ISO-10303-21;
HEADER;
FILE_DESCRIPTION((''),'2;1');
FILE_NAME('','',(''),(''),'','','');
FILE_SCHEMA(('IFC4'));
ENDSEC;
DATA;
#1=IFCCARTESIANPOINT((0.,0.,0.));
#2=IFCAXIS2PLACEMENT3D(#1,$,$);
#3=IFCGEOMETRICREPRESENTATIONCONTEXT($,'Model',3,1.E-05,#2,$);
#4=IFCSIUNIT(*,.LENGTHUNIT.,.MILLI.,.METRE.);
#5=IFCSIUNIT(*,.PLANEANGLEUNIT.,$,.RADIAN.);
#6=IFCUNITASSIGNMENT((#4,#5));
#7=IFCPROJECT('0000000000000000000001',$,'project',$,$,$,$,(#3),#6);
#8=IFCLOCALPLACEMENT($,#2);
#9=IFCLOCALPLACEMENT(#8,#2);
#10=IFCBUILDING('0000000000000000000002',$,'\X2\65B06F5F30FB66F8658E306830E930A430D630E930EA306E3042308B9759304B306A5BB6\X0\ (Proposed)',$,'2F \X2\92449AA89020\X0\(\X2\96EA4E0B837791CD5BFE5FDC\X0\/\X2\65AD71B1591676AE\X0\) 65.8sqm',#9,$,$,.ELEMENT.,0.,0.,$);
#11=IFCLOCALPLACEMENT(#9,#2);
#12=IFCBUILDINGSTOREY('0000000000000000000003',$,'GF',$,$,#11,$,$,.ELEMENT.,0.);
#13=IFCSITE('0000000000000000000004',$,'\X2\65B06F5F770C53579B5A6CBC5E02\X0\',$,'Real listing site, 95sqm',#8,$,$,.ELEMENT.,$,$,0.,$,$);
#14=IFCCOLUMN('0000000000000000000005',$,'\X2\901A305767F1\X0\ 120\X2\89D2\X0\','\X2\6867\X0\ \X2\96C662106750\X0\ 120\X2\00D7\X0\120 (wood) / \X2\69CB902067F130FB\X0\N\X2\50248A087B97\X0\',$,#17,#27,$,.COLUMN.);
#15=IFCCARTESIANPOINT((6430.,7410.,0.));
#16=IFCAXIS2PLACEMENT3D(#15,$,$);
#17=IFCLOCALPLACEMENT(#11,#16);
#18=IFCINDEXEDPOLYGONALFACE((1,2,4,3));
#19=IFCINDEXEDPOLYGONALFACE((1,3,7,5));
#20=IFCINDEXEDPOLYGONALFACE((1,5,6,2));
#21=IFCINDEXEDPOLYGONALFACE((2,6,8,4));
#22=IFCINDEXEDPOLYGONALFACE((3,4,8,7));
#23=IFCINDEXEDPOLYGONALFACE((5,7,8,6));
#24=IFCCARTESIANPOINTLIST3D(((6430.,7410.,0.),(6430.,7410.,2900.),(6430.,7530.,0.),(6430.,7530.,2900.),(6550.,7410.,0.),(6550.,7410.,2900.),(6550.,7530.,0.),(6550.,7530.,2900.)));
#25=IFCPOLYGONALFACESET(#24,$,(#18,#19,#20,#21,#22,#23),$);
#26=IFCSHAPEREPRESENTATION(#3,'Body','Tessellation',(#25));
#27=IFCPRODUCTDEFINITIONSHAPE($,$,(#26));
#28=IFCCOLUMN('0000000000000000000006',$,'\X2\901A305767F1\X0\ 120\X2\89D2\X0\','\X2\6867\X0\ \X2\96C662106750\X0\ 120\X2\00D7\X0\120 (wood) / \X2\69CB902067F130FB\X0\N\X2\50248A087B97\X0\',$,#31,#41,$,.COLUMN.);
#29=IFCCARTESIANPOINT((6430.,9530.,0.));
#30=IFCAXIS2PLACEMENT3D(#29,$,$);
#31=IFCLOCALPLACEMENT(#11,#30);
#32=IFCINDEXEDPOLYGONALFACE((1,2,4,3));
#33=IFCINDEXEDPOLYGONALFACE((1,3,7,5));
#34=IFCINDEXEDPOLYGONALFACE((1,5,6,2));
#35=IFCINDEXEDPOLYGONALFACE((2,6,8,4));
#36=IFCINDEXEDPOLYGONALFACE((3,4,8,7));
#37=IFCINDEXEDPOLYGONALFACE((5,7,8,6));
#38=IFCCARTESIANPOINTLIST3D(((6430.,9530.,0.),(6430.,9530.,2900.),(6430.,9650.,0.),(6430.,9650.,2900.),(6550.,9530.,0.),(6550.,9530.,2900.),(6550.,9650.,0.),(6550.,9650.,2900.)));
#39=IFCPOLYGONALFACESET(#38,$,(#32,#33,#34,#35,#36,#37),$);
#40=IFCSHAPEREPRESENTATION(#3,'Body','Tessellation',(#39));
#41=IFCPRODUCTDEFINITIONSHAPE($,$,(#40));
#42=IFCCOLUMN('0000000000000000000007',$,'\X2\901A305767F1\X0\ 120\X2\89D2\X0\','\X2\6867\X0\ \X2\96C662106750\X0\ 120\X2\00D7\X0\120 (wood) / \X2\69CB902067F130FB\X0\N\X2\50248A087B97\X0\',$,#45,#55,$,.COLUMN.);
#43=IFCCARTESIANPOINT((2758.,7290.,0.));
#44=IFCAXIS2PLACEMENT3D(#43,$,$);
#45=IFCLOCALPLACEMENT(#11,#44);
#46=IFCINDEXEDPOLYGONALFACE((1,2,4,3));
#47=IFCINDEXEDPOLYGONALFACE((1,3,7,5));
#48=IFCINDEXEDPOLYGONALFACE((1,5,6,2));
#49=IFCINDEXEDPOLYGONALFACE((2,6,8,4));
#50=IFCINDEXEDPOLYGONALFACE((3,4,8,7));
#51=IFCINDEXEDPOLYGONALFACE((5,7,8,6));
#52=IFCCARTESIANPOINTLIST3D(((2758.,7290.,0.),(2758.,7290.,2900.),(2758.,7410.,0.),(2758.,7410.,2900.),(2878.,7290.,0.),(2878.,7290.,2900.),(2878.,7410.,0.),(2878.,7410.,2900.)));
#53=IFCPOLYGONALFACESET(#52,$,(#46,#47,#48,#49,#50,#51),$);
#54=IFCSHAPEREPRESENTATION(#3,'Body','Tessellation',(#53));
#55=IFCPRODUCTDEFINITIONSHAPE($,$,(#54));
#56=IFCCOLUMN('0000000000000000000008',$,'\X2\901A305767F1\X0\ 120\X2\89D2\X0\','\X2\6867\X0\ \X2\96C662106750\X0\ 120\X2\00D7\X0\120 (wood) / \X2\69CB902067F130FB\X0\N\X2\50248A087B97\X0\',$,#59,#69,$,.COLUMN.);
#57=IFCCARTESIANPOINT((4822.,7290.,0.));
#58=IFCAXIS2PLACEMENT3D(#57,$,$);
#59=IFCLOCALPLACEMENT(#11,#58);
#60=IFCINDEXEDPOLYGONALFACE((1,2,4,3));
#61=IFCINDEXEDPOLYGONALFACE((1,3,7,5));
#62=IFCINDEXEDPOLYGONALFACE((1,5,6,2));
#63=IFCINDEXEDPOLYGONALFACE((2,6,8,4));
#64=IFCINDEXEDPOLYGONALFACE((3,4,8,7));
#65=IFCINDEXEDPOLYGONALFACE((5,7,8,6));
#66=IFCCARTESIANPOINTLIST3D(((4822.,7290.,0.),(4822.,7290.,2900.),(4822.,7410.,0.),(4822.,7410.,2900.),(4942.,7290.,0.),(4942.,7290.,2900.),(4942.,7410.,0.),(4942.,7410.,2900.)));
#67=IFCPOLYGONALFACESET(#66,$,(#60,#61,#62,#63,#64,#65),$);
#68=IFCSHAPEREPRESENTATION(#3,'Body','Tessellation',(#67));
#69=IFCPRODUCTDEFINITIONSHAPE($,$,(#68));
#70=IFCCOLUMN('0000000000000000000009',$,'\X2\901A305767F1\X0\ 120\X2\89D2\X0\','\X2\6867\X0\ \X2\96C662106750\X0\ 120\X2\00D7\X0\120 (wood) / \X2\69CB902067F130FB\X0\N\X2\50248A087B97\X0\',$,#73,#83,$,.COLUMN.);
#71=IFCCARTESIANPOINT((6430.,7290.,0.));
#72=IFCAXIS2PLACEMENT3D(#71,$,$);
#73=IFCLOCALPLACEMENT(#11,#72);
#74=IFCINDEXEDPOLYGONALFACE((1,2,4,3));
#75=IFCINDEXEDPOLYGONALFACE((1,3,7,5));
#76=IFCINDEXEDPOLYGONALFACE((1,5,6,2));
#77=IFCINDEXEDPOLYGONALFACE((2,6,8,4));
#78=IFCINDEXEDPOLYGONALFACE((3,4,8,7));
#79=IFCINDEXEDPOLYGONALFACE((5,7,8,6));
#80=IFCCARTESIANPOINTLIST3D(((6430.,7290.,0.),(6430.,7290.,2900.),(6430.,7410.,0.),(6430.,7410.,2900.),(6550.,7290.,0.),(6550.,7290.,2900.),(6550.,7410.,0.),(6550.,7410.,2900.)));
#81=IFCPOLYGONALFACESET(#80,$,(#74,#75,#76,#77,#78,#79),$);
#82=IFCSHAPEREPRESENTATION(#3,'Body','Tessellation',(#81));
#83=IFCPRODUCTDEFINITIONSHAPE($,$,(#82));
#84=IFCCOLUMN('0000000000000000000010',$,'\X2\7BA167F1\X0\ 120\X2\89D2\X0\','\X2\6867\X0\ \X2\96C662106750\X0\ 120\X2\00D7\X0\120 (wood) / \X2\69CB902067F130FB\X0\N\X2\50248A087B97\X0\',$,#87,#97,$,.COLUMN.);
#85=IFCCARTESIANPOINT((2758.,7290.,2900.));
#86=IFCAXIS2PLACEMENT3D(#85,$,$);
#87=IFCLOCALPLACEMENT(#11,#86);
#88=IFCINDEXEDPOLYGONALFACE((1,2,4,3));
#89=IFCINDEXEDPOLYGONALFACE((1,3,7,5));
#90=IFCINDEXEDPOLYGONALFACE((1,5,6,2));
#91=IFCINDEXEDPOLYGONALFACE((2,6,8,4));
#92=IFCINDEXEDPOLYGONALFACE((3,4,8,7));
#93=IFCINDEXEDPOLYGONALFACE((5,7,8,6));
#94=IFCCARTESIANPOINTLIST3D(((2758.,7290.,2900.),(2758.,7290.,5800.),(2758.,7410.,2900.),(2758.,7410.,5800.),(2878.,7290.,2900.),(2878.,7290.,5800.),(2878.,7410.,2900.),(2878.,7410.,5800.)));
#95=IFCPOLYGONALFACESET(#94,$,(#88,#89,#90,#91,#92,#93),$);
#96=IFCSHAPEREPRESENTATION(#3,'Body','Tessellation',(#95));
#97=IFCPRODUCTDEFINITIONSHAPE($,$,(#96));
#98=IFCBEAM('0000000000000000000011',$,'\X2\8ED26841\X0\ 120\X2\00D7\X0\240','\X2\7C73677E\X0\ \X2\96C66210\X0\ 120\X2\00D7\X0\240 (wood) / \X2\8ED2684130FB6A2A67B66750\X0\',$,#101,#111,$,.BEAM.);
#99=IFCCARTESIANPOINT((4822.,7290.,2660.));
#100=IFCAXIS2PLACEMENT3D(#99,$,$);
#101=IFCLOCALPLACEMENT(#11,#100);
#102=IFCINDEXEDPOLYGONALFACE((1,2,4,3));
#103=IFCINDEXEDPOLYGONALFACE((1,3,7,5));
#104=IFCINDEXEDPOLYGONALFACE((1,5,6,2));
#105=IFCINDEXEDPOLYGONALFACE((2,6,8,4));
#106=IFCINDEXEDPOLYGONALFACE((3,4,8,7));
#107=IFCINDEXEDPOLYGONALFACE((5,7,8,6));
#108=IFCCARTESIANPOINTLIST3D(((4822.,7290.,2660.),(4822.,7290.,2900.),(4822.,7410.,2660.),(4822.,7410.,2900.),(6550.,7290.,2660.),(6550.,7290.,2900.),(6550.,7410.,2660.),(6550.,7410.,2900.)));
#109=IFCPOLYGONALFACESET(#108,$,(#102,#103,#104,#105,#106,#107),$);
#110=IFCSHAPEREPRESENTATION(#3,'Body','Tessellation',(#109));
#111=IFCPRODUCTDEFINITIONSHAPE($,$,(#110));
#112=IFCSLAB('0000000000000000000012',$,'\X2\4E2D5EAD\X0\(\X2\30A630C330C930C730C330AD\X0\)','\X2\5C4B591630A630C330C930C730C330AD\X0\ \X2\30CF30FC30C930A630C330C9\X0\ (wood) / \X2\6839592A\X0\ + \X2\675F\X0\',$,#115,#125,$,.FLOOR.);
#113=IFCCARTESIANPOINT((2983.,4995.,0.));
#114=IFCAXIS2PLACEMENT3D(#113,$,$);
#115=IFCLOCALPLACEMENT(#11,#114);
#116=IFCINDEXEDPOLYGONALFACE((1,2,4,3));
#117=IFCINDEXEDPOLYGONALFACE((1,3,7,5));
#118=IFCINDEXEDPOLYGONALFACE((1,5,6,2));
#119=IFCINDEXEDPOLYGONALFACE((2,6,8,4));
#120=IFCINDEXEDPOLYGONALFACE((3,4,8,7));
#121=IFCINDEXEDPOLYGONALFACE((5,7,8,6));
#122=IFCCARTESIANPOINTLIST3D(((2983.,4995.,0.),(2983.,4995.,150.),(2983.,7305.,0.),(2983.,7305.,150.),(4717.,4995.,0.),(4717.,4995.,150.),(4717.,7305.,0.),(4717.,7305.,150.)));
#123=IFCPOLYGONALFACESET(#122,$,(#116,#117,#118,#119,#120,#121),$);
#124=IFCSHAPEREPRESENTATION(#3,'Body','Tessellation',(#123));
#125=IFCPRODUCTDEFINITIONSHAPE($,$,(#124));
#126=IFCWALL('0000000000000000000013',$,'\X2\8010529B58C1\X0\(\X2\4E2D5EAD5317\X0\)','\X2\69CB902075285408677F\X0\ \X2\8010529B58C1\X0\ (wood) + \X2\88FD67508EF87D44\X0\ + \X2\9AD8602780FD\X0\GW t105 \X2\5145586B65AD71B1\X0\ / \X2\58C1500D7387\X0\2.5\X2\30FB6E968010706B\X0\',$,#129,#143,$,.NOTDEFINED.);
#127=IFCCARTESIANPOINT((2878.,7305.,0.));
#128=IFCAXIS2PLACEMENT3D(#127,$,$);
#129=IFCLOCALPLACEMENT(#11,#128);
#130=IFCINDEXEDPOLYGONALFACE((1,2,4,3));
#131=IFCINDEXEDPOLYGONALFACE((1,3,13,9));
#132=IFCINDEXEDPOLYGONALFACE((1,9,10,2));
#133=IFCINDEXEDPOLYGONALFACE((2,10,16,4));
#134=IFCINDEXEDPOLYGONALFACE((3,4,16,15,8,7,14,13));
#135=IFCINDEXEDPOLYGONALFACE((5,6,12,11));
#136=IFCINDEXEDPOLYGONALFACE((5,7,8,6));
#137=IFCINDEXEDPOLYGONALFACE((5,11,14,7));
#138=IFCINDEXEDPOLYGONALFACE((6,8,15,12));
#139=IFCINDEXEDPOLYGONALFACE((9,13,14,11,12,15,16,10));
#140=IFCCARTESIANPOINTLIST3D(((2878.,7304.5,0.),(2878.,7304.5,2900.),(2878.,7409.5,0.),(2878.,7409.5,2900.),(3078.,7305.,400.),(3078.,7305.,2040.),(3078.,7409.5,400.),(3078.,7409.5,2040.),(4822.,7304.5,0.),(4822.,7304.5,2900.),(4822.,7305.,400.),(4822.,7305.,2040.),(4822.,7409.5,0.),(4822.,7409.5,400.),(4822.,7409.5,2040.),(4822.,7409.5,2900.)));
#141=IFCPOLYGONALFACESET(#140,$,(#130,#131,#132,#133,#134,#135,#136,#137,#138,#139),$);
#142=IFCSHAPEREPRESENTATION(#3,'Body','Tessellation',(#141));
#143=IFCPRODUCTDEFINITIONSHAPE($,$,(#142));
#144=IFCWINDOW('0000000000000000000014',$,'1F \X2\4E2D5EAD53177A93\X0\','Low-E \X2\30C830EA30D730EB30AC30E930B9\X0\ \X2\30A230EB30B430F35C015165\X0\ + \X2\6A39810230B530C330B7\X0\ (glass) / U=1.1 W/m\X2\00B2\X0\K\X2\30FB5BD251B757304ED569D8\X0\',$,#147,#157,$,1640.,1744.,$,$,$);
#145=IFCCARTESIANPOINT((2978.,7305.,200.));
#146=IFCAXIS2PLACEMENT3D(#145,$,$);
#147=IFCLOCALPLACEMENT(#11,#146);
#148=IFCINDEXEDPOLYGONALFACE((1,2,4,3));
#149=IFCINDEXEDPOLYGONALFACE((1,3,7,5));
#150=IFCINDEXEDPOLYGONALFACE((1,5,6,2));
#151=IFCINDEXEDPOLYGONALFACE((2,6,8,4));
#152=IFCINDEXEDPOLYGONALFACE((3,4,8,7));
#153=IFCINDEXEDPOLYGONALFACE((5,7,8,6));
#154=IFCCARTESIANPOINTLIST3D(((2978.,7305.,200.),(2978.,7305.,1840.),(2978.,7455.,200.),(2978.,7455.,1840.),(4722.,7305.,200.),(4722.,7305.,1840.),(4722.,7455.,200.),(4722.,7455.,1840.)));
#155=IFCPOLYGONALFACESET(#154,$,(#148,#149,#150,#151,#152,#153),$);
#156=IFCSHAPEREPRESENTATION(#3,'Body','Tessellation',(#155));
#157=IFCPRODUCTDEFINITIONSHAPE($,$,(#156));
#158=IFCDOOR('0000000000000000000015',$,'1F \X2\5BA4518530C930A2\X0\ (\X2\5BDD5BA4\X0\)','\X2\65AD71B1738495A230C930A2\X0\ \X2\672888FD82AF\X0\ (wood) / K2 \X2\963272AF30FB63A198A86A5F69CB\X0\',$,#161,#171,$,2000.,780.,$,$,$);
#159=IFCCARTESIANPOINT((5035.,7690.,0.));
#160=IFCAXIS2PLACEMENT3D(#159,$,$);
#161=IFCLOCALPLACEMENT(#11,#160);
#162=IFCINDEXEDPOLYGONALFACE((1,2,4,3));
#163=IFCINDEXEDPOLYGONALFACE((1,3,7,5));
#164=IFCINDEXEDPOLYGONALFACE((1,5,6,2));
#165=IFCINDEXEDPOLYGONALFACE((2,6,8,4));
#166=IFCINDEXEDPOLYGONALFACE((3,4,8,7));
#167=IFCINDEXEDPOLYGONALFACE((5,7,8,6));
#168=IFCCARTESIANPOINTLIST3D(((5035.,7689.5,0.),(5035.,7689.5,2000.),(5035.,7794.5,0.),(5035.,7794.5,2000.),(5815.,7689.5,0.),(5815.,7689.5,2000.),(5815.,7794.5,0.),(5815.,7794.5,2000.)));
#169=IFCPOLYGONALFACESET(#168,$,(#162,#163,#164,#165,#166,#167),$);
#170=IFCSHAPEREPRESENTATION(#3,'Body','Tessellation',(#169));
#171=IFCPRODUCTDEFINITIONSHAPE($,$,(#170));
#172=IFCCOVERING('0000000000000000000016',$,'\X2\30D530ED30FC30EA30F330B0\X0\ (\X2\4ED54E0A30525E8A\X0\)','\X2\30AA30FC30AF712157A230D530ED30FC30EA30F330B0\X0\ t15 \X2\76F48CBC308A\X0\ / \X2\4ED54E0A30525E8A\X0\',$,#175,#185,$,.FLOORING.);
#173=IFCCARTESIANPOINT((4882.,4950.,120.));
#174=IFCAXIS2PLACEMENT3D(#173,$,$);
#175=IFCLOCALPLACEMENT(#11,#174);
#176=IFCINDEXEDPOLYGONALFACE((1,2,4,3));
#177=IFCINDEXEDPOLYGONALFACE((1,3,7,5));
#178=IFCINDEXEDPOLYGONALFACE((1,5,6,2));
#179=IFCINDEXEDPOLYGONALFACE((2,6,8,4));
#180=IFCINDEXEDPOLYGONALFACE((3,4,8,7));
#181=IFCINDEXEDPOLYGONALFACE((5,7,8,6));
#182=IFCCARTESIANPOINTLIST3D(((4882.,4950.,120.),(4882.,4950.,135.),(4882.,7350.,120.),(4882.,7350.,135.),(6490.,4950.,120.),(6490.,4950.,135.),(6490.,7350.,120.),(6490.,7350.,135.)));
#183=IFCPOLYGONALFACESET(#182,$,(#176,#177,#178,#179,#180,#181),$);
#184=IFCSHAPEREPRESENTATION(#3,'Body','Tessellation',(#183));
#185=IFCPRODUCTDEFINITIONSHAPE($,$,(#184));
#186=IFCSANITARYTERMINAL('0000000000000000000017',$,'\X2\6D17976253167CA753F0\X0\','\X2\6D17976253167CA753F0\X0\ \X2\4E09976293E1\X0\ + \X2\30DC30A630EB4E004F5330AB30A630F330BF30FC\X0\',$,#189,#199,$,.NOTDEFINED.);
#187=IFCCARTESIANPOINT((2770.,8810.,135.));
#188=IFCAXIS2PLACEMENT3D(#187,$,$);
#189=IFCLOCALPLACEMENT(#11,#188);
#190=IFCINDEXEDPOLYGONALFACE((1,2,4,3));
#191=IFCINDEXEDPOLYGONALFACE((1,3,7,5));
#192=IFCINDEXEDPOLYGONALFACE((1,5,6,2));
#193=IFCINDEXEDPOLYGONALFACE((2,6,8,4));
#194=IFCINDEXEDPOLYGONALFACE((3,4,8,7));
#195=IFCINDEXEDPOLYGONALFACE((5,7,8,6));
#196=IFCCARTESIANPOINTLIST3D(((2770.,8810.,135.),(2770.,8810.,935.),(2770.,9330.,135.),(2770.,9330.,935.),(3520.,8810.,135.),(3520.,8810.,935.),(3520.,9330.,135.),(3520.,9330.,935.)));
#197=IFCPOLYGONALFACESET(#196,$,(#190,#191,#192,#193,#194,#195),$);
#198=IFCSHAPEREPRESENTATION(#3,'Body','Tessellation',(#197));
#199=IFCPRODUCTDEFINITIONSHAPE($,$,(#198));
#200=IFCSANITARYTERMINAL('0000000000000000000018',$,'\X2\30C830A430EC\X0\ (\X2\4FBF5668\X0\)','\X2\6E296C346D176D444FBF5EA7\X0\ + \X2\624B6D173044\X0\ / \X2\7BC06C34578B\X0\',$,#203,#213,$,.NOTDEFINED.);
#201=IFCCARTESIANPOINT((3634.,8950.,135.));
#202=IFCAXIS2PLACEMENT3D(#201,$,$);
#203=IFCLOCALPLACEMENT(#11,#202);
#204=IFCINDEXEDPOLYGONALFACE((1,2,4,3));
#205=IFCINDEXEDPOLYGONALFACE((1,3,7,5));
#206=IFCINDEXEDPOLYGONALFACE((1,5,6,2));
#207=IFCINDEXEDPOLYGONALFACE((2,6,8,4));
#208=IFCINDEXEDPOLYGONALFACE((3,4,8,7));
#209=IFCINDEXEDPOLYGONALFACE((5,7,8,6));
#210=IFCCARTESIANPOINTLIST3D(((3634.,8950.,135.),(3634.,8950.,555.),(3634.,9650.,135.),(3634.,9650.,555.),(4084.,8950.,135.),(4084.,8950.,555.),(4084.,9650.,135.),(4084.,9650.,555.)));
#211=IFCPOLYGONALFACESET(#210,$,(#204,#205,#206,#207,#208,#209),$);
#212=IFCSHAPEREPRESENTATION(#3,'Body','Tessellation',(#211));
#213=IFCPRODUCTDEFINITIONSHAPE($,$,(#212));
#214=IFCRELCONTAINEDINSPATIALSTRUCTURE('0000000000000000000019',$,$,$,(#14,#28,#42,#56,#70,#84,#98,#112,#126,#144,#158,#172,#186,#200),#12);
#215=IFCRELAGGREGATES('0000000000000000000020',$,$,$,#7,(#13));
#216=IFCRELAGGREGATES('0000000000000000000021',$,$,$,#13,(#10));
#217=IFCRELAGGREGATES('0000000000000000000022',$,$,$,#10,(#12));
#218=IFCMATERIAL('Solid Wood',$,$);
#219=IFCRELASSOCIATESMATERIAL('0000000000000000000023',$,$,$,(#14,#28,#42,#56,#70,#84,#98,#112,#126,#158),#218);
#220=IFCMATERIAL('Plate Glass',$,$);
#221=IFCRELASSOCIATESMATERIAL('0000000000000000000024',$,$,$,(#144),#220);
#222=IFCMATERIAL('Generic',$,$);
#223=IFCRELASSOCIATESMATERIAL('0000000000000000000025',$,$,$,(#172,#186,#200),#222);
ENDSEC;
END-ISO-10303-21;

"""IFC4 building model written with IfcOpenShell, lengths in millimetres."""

from ifc_helpers import new_model, si_unit, frame, frame_2d, origin, place, context, project, spatial, rectangle, extrude, material, element, fill, save


model = new_model("IFC4")

# Units and contexts
model_context = context("Model", 3, precision=1e-05, world=origin())
ifc_project = project(units=[si_unit("LENGTHUNIT", "METRE", prefix="MILLI"), si_unit("PLANEANGLEUNIT", "RADIAN")], contexts=[model_context])

# Site, building, storey
site_placement = place(None, origin())
site = spatial("IfcSite", under=ifc_project, at=site_placement, Name="新潟県南魚沼市", ObjectType="Real listing site, 95sqm", CompositionType="ELEMENT", RefElevation=0.0)
building_placement = place(site_placement, origin())
building = spatial("IfcBuilding", under=site, at=building_placement, Name="新潟・書斎とライブラリのある静かな家 (Proposed)", ObjectType="2F 鉄骨造(雪下荷重対応/断熱外皮) 65.8sqm", CompositionType="ELEMENT", ElevationOfRefHeight=0.0, ElevationOfTerrain=0.0)
storey_placement = place(building_placement, origin())
storey = spatial("IfcBuildingStorey", under=building, at=storey_placement, Name="GF", CompositionType="ELEMENT", Elevation=0.0)

# Columns
ifc_material_1 = material(Name="Solid Wood")
column_1_placement = place(storey_placement, frame((6430.0, 7410.0, 0.0)))
element("IfcColumn", 1, at=column_1_placement, inside=storey, material=ifc_material_1, Name="通し柱 120角", Description="桧 集成材 120×120 (wood) / 構造柱・N値計算", PredefinedType="COLUMN", context=model_context, shape_type="SweptSolid", body=[
    extrude(rectangle(XDim=120.0, YDim=120.0, at=frame_2d((60.0, 60.0))), frame((6430.0, 7410.0, 0.0)), (0.0, 0.0, 1.0), 2900.0),
])
column_2_placement = place(storey_placement, frame((6430.0, 9530.0, 0.0)))
element("IfcColumn", 2, at=column_2_placement, inside=storey, material=ifc_material_1, Name="通し柱 120角", Description="桧 集成材 120×120 (wood) / 構造柱・N値計算", PredefinedType="COLUMN", context=model_context, shape_type="SweptSolid", body=[
    extrude(rectangle(XDim=120.0, YDim=120.0, at=frame_2d((60.0, 60.0))), frame((6430.0, 9530.0, 0.0)), (0.0, 0.0, 1.0), 2900.0),
])
column_3_placement = place(storey_placement, frame((2758.0, 7290.0, 0.0)))
element("IfcColumn", 3, at=column_3_placement, inside=storey, material=ifc_material_1, Name="通し柱 120角", Description="桧 集成材 120×120 (wood) / 構造柱・N値計算", PredefinedType="COLUMN", context=model_context, shape_type="SweptSolid", body=[
    extrude(rectangle(XDim=120.0, YDim=120.0, at=frame_2d((60.0, 60.0))), frame((2758.0, 7290.0, 0.0)), (0.0, 0.0, 1.0), 2900.0),
])
column_4_placement = place(storey_placement, frame((4822.0, 7290.0, 0.0)))
element("IfcColumn", 4, at=column_4_placement, inside=storey, material=ifc_material_1, Name="通し柱 120角", Description="桧 集成材 120×120 (wood) / 構造柱・N値計算", PredefinedType="COLUMN", context=model_context, shape_type="SweptSolid", body=[
    extrude(rectangle(XDim=120.0, YDim=120.0, at=frame_2d((60.0, 60.0))), frame((4822.0, 7290.0, 0.0)), (0.0, 0.0, 1.0), 2900.0),
])
column_5_placement = place(storey_placement, frame((6430.0, 7290.0, 0.0)))
element("IfcColumn", 5, at=column_5_placement, inside=storey, material=ifc_material_1, Name="通し柱 120角", Description="桧 集成材 120×120 (wood) / 構造柱・N値計算", PredefinedType="COLUMN", context=model_context, shape_type="SweptSolid", body=[
    extrude(rectangle(XDim=120.0, YDim=120.0, at=frame_2d((60.0, 60.0))), frame((6430.0, 7290.0, 0.0)), (0.0, 0.0, 1.0), 2900.0),
])
column_6_placement = place(storey_placement, frame((2758.0, 7290.0, 2900.0)))
element("IfcColumn", 6, at=column_6_placement, inside=storey, material=ifc_material_1, Name="管柱 120角", Description="桧 集成材 120×120 (wood) / 構造柱・N値計算", PredefinedType="COLUMN", context=model_context, shape_type="SweptSolid", body=[
    extrude(rectangle(XDim=120.0, YDim=120.0, at=frame_2d((60.0, 60.0))), frame((2758.0, 7290.0, 2900.0)), (0.0, 0.0, 1.0), 2900.0),
])

# Beam
beam_1_placement = place(storey_placement, frame((4822.0, 7290.0, 2660.0)))
element("IfcBeam", 7, at=beam_1_placement, inside=storey, material=ifc_material_1, Name="軒桁 120×240", Description="米松 集成 120×240 (wood) / 軒桁・横架材", PredefinedType="BEAM", context=model_context, shape_type="SweptSolid", body=[
    extrude(rectangle(XDim=1728.0, YDim=120.0, at=frame_2d((864.0, 60.0))), frame((4822.0, 7290.0, 2660.0)), (0.0, 0.0, 1.0), 240.0),
])

# Slab
slab_placement = place(storey_placement, frame((2983.0, 4995.0, 0.0)))
element("IfcSlab", 8, at=slab_placement, inside=storey, material=ifc_material_1, Name="中庭(ウッドデッキ)", Description="屋外ウッドデッキ ハードウッド (wood) / 根太 + 束", PredefinedType="FLOOR", context=model_context, shape_type="SweptSolid", body=[
    extrude(rectangle(XDim=1734.0, YDim=2310.0, at=frame_2d((867.0, 1155.0))), frame((2983.0, 4995.0, 0.0)), (0.0, 0.0, 1.0), 150.0),
])

# Wall, opening, window
wall_1_placement = place(storey_placement, frame((2878.0, 7305.0, 0.0)))
wall_1 = element("IfcWall", 9, at=wall_1_placement, inside=storey, material=ifc_material_1, Name="耐力壁(中庭北)", Description="構造用合板 耐力壁 (wood) + 製材軸組 + 高性能GW t105 充填断熱 / 壁倍率2.5・準耐火", PredefinedType="NOTDEFINED", context=model_context, shape_type="SweptSolid", body=[
    extrude(rectangle(XDim=1944.0, YDim=105.0, at=frame_2d((972.0, 52.0))), frame((2878.0, 7305.0, 0.0)), (0.0, 0.0, 1.0), 2900.0),
])
opening_placement = place(storey_placement, frame((2978.0, 7305.0, 200.0)))
opening = element("IfcOpeningElement", 10, at=opening_placement, cuts=wall_1, PredefinedType="NOTDEFINED", context=model_context, shape_type="SweptSolid", body=[
    extrude(rectangle(XDim=1744.0, YDim=150.0, at=frame_2d((872.0, 75.0))), frame((2978.0, 7305.0, 200.0)), (0.0, 0.0, 1.0), 1640.0),
])
ifc_material_2 = material(Name="Plate Glass")
window_placement = place(storey_placement, frame((2978.0, 7305.0, 200.0)))
window = element("IfcWindow", 11, at=window_placement, inside=storey, material=ifc_material_2, Name="1F 中庭北窓", Description="Low-E トリプルガラス アルゴン封入 + 樹脂サッシ (glass) / U=1.1 W/m²K・寒冷地仕様", OverallHeight=1640.0, OverallWidth=1744.0, context=model_context, shape_type="SweptSolid", body=[
    extrude(rectangle(XDim=1744.0, YDim=150.0, at=frame_2d((872.0, 75.0))), frame((2978.0, 7305.0, 200.0)), (0.0, 0.0, 1.0), 1640.0),
])
fill(opening, window)

# Door
door_placement = place(storey_placement, frame((5035.0, 7690.0, 0.0)))
element("IfcDoor", 12, at=door_placement, inside=storey, material=ifc_material_1, Name="1F 室内ドア (寝室)", Description="断熱玄関ドア 木製芯 (wood) / K2 防犯・採風機構", OverallHeight=2000.0, OverallWidth=780.0, context=model_context, shape_type="SweptSolid", body=[
    extrude(rectangle(XDim=780.0, YDim=105.0, at=frame_2d((390.0, 52.0))), frame((5035.0, 7690.0, 0.0)), (0.0, 0.0, 1.0), 2000.0),
])

# Covering
ifc_material_3 = material(Name="Generic")
covering_placement = place(storey_placement, frame((4882.0, 4950.0, 120.0)))
element("IfcCovering", 13, at=covering_placement, inside=storey, material=ifc_material_3, Name="フローリング (仕上げ床)", Description="オーク無垢フローリング t15 直貼り / 仕上げ床", PredefinedType="FLOORING", context=model_context, shape_type="SweptSolid", body=[
    extrude(rectangle(XDim=1608.0, YDim=2400.0, at=frame_2d((804.0, 1200.0))), frame((4882.0, 4950.0, 120.0)), (0.0, 0.0, 1.0), 15.0),
])

# Sanitary terminals
sanitary_terminal_1_placement = place(storey_placement, frame((2770.0, 8810.0, 135.0)))
element("IfcSanitaryTerminal", 14, at=sanitary_terminal_1_placement, inside=storey, material=ifc_material_3, Name="洗面化粧台", Description="洗面化粧台 三面鏡 + ボウル一体カウンター", PredefinedType="NOTDEFINED", context=model_context, shape_type="SweptSolid", body=[
    extrude(rectangle(XDim=750.0, YDim=520.0, at=frame_2d((375.0, 260.0))), frame((2770.0, 8810.0, 135.0)), (0.0, 0.0, 1.0), 800.0),
])
sanitary_terminal_2_placement = place(storey_placement, frame((3634.0, 8950.0, 135.0)))
element("IfcSanitaryTerminal", 15, at=sanitary_terminal_2_placement, inside=storey, material=ifc_material_3, Name="トイレ (便器)", Description="温水洗浄便座 + 手洗い / 節水型", PredefinedType="NOTDEFINED", context=model_context, shape_type="SweptSolid", body=[
    extrude(rectangle(XDim=450.0, YDim=700.0, at=frame_2d((225.0, 350.0))), frame((3634.0, 8950.0, 135.0)), (0.0, 0.0, 1.0), 420.0),
])

save(model, "model.ifc")
